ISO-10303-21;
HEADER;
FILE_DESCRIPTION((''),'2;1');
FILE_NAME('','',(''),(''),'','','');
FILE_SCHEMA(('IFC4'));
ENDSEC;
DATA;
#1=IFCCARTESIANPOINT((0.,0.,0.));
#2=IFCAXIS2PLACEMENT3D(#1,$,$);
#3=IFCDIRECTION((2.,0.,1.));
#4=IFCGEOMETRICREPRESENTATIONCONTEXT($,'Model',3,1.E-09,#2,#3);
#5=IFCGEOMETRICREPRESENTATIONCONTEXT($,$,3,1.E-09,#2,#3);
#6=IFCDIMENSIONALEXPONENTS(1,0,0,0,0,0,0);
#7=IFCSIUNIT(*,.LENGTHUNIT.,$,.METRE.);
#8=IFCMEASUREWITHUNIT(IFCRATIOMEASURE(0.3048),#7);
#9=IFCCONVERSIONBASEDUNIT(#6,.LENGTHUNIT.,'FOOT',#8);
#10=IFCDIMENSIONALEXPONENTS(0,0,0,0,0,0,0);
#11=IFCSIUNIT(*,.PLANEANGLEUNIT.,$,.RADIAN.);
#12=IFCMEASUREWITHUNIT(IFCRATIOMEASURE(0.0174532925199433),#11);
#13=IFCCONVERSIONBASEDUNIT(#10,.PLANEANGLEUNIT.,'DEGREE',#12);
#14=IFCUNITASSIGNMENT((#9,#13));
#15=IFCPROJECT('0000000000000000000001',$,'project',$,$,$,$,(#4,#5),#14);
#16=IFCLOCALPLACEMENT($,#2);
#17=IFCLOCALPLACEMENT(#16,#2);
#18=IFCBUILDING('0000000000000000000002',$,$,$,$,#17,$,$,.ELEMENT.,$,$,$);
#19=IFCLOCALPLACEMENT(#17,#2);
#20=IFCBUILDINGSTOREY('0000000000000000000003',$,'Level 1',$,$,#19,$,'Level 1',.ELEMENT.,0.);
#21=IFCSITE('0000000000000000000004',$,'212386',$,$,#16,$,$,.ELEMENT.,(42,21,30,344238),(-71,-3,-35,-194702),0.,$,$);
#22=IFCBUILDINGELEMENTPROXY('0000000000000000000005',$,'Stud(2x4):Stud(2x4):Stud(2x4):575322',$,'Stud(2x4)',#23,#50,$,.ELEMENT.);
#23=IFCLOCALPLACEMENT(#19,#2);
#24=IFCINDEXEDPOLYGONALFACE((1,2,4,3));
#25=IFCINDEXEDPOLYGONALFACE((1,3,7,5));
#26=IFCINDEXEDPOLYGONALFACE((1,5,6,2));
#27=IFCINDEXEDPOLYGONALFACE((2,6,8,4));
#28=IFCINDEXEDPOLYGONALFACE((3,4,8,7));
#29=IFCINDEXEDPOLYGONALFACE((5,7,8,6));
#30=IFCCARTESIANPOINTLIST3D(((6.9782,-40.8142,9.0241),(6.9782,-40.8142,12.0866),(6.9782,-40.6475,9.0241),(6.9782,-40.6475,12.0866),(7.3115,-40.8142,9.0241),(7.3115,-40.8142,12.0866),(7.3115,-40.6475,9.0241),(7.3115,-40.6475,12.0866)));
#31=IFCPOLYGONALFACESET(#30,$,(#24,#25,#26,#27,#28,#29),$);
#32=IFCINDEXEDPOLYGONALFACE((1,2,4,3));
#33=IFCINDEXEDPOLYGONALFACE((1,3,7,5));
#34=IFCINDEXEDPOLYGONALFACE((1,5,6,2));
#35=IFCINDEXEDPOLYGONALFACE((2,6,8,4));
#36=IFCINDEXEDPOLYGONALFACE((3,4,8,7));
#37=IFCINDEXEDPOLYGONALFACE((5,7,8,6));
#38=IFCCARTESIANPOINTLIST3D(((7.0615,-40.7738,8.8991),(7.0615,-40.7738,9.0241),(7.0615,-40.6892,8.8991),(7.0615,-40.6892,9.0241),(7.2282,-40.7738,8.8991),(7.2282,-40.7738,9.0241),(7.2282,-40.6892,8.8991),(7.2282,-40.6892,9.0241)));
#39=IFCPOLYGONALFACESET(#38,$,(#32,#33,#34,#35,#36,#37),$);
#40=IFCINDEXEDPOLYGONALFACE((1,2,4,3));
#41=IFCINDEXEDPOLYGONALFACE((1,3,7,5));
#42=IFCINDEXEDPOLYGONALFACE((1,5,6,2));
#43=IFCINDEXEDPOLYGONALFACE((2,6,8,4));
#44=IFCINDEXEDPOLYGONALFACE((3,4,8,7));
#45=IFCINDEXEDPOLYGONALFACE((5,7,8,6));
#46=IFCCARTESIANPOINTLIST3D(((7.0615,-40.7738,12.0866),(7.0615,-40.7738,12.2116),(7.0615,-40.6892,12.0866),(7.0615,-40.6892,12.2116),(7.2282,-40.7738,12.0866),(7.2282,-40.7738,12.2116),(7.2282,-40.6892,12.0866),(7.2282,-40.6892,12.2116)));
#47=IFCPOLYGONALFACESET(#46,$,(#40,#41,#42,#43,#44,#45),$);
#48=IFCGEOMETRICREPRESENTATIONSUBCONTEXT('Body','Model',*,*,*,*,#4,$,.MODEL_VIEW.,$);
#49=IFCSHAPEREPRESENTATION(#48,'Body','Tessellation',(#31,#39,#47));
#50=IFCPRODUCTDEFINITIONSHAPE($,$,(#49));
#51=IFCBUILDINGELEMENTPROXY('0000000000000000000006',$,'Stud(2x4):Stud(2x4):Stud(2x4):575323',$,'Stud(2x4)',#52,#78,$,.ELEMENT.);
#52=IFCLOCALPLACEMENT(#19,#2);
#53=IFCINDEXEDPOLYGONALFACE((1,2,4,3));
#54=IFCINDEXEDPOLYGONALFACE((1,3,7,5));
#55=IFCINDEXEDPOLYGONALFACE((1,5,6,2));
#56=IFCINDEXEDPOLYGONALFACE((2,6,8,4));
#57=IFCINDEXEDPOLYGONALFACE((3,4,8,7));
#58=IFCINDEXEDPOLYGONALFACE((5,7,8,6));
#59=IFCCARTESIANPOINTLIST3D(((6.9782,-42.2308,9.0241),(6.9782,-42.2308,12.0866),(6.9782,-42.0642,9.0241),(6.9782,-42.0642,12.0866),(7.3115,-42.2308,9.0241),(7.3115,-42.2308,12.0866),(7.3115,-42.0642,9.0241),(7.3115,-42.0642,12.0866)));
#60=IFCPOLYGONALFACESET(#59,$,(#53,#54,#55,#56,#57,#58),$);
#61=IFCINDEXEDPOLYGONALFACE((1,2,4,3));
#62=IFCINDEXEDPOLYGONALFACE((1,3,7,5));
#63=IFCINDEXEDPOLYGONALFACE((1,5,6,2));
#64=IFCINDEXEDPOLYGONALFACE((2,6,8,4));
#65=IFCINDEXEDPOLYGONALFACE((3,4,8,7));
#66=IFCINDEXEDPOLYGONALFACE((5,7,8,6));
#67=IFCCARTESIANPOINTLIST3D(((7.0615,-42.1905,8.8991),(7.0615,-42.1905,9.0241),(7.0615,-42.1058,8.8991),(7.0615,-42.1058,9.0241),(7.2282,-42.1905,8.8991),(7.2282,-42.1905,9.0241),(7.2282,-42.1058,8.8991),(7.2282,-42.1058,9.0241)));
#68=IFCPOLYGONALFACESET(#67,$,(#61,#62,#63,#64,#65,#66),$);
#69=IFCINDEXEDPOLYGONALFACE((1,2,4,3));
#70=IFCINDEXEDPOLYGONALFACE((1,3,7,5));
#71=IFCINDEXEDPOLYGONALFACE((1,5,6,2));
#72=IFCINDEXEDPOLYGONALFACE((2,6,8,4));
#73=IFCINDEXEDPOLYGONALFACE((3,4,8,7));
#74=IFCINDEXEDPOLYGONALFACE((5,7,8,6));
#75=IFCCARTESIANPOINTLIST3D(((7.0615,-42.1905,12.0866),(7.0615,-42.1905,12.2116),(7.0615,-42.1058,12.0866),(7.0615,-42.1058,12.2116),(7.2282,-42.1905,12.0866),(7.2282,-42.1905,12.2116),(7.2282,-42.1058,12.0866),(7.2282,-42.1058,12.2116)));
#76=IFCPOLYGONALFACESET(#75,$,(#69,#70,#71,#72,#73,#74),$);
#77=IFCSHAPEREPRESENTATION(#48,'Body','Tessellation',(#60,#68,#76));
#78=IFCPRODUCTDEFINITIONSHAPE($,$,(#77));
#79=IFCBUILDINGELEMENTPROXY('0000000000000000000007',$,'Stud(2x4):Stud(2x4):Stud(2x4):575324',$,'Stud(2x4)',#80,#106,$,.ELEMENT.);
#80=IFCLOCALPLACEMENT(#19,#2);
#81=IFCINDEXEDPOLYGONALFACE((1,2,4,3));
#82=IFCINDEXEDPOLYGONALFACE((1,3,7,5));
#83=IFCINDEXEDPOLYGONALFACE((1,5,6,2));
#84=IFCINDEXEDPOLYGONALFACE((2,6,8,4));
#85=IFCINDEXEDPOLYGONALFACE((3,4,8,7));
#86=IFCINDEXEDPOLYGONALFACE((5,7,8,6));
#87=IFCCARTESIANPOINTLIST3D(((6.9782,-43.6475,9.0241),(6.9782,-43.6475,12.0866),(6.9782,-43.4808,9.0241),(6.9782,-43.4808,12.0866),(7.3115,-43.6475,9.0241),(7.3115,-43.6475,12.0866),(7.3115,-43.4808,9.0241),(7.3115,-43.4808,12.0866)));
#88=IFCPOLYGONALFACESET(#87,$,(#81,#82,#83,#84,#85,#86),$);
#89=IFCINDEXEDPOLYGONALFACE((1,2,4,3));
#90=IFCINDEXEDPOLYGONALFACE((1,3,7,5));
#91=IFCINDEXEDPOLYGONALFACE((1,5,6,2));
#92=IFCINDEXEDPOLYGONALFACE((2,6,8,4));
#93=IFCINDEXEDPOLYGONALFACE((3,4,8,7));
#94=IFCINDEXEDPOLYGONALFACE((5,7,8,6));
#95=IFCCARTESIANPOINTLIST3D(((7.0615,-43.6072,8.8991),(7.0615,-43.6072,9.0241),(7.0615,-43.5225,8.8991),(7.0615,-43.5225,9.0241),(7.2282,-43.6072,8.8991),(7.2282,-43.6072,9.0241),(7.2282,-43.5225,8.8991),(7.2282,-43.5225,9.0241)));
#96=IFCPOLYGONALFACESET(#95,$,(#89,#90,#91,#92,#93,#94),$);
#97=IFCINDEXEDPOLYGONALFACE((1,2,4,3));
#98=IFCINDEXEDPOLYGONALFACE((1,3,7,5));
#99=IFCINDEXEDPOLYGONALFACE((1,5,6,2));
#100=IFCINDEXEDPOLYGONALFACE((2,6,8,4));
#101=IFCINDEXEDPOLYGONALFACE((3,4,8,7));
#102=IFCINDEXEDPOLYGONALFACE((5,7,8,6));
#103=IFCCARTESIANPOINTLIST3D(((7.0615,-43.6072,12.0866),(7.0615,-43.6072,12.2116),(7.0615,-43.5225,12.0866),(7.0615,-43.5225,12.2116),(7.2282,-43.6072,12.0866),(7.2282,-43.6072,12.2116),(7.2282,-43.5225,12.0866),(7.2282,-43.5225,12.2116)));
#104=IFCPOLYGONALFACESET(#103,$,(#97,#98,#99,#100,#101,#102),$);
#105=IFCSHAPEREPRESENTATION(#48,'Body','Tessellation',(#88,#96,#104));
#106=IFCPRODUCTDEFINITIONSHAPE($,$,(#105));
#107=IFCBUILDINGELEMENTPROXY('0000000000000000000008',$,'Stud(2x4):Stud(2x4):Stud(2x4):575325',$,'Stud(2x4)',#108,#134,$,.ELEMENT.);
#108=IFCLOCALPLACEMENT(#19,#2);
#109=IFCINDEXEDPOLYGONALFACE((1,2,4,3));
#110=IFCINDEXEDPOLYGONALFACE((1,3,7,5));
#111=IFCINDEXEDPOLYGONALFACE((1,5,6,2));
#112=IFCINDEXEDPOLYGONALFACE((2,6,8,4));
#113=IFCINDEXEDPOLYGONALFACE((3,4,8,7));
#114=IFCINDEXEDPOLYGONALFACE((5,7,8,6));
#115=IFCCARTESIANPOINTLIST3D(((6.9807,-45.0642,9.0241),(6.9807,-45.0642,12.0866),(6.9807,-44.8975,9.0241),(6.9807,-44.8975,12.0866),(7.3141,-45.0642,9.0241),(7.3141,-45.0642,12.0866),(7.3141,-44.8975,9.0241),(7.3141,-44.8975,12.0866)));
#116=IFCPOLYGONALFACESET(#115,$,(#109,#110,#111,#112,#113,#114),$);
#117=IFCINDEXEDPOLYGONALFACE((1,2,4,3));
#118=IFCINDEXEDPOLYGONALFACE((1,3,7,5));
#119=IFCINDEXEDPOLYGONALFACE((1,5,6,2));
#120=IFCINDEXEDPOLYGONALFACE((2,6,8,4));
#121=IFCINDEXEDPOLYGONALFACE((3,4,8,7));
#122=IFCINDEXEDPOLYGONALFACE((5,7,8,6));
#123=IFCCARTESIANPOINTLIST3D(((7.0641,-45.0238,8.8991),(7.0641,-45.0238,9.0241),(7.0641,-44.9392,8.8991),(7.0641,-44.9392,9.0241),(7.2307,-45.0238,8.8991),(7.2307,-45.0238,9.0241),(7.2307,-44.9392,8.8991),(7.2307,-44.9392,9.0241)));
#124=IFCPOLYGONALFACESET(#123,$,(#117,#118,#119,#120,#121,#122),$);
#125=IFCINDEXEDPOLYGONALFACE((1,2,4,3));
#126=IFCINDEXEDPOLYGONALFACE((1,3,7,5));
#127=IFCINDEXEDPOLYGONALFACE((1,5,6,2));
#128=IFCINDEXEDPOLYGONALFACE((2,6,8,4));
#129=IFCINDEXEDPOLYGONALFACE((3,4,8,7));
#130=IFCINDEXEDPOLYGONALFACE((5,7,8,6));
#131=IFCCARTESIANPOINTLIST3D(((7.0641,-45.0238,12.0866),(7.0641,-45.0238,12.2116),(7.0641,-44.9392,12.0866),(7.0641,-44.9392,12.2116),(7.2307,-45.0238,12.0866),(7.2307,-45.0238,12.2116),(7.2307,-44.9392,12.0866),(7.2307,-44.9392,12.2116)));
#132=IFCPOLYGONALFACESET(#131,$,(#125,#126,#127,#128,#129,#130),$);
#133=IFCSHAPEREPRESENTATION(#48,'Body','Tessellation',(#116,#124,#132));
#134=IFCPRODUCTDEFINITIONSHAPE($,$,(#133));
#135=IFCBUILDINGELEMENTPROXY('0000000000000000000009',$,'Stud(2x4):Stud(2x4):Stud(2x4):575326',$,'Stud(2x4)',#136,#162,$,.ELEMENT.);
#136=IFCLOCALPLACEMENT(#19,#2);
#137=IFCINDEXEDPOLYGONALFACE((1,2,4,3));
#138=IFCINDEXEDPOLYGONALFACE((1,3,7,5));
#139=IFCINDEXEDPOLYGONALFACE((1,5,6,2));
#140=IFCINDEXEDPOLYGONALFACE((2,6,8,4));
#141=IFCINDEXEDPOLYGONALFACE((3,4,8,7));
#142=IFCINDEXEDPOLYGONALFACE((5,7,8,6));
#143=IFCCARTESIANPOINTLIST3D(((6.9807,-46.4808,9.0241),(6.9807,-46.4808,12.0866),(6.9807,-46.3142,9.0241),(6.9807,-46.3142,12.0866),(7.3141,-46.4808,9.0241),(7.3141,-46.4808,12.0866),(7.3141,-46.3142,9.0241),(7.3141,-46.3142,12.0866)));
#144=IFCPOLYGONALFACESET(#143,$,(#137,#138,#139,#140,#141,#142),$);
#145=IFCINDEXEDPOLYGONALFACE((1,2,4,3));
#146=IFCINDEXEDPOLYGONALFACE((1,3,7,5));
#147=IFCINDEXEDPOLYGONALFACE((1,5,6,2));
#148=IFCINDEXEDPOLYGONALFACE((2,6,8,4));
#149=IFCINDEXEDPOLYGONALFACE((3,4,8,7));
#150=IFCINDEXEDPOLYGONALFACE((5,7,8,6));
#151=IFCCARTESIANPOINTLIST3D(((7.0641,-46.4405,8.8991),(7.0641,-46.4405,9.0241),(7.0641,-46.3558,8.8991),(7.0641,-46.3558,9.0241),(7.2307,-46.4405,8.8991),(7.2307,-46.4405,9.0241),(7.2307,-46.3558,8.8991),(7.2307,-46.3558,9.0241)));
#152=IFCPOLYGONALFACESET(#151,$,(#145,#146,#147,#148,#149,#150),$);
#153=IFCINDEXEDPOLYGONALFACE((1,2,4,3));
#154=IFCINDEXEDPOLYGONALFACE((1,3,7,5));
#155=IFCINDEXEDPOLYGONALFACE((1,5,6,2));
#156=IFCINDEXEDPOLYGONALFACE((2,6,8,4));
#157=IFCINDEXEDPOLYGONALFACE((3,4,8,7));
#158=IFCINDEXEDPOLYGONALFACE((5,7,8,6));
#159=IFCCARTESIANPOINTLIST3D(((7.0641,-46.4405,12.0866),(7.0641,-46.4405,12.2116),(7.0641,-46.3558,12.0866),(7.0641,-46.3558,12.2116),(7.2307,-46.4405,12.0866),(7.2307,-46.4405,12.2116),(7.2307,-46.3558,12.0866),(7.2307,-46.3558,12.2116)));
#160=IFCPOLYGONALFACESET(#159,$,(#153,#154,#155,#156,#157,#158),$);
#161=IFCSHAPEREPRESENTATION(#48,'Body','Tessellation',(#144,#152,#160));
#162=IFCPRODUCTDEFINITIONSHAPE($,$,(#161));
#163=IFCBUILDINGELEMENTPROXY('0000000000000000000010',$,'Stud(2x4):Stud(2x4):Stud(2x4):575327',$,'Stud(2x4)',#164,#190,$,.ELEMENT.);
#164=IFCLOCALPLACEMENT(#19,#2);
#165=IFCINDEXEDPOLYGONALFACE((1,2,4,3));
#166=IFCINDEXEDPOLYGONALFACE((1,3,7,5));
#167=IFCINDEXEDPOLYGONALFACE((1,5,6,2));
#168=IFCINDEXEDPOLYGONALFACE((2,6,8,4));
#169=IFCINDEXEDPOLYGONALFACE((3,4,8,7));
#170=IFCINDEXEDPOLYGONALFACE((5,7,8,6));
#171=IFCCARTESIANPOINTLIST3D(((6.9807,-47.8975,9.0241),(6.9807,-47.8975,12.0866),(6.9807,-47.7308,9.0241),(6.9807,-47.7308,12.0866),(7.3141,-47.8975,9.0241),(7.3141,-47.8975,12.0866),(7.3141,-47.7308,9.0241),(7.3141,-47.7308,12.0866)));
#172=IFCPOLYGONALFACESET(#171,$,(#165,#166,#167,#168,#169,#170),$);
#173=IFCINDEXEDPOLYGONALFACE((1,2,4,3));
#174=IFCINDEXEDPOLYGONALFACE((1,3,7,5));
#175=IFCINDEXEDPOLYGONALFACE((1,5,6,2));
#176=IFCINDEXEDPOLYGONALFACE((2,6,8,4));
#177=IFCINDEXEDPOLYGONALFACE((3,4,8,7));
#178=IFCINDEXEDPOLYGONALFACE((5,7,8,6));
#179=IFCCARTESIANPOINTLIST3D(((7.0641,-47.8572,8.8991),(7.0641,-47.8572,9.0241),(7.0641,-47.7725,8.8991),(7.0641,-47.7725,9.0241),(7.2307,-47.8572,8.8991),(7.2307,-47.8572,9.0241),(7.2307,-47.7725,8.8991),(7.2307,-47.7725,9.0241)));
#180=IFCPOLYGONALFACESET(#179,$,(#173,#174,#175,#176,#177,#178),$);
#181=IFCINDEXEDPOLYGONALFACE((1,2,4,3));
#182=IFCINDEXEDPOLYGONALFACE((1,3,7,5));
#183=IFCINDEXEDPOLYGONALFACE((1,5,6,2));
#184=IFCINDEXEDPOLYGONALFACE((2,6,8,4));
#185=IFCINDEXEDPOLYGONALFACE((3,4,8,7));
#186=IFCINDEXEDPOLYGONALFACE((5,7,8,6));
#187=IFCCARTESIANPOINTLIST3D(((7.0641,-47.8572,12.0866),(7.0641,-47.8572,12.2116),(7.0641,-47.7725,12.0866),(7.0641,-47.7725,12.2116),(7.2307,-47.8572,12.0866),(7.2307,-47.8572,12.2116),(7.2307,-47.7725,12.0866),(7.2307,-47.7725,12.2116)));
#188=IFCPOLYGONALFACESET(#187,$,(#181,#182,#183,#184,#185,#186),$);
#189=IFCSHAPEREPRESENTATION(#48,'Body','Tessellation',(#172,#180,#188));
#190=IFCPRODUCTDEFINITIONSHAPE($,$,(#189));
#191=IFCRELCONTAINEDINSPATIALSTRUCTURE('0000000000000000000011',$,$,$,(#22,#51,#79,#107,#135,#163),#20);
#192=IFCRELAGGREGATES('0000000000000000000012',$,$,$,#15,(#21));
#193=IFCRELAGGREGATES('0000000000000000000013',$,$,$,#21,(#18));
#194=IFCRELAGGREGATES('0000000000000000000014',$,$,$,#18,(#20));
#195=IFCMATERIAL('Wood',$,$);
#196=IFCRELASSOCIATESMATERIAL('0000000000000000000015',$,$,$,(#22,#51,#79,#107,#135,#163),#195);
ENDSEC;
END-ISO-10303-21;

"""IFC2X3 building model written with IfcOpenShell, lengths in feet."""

from ifc_helpers import new_model, entity, si_unit, converted_unit, direction, frame, frame_2d, origin, place, context, subcontext, project, spatial, rectangle, extrude, source, transform, mapped, material, element, save


model = new_model("IFC2X3")

# Units and contexts
model_context = context("Model", 3, precision=1e-09, world=origin(), true_north=direction((2.0, 0.0, 1.0)))
context_of_model = context(None, 3, precision=1e-09, world=origin(), true_north=direction((2.0, 0.0, 1.0)))
body_context = subcontext(model_context, "Body", "Model", "MODEL_VIEW")
ifc_project = project(units=[converted_unit("LENGTHUNIT", "FOOT", entity("IfcRatioMeasure", 0.3048), si_unit("LENGTHUNIT", "METRE"), dimensions=[1, 0, 0, 0, 0, 0, 0]), converted_unit("PLANEANGLEUNIT", "DEGREE", entity("IfcRatioMeasure", 0.0174532925199433), si_unit("PLANEANGLEUNIT", "RADIAN"), dimensions=[0, 0, 0, 0, 0, 0, 0])], contexts=[model_context, context_of_model])

# Site, building, storey
site_placement = place(None, origin())
site = spatial("IfcSite", under=ifc_project, at=site_placement, Name="212386", CompositionType="ELEMENT", RefLatitude=(42, 21, 30, 344238), RefLongitude=(-71, -3, -35, -194702), RefElevation=0.0)
building_placement = place(site_placement, origin())
building = spatial("IfcBuilding", under=site, at=building_placement, CompositionType="ELEMENT")
storey_placement = place(building_placement, origin())
storey = spatial("IfcBuildingStorey", under=building, at=storey_placement, Name="Level 1", LongName="Level 1", CompositionType="ELEMENT", Elevation=0.0)

# Building element proxies
ifc_material = material(Name="Wood")
shared_shape_1 = source(origin(), body_context, "Body", "SweptSolid", [
    extrude(rectangle(XDim=0.3333, YDim=0.1667, at=frame_2d((0.0, 0.0), x_axis=(1.0, 0.0))), frame((7.1448, -40.7308, 9.0241), z_axis=(0.0, 0.0, 1.0), x_axis=(-1.0, 0.0, 0.0)), (0.0, 0.0, 1.0), 3.0625),
    extrude(rectangle(XDim=0.1667, YDim=0.0847, at=frame_2d((0.0, 0.0), x_axis=(1.0, 0.0))), frame((7.1448, -40.7315, 8.8991), z_axis=(0.0, 0.0, 1.0), x_axis=(-1.0, 0.0, 0.0)), (0.0, 0.0, 1.0), 0.125),
    extrude(rectangle(XDim=0.0847, YDim=0.1667, at=frame_2d((0.0, 0.0), x_axis=(1.0, 0.0))), frame((7.1448, -40.7315, 12.0866), z_axis=(0.0, 0.0, 1.0), x_axis=(0.0, -1.0, 0.0)), (0.0, 0.0, 1.0), 0.125),
])
proxy_1_placement = place(storey_placement, origin())
element("IfcBuildingElementProxy", 1, at=proxy_1_placement, inside=storey, material=ifc_material, Name="Stud(2x4):Stud(2x4):Stud(2x4):575322", ObjectType="Stud(2x4)", CompositionType="ELEMENT", context=body_context, shape_type="MappedRepresentation", body=[
    mapped(shared_shape_1, transform((0.0, 0.0, 0.0), scale=1.0)),
])
shared_shape_2 = source(origin(), body_context, "Body", "SweptSolid", [
    extrude(rectangle(XDim=0.3333, YDim=0.1667, at=frame_2d((0.0, 0.0), x_axis=(1.0, 0.0))), frame((7.1448, -42.1475, 9.0241), z_axis=(0.0, 0.0, 1.0), x_axis=(-1.0, 0.0, 0.0)), (0.0, 0.0, 1.0), 3.0625),
    extrude(rectangle(XDim=0.1667, YDim=0.0847, at=frame_2d((0.0, 0.0), x_axis=(1.0, 0.0))), frame((7.1448, -42.1482, 8.8991), z_axis=(0.0, 0.0, 1.0), x_axis=(-1.0, 0.0, 0.0)), (0.0, 0.0, 1.0), 0.125),
    extrude(rectangle(XDim=0.0847, YDim=0.1667, at=frame_2d((0.0, 0.0), x_axis=(1.0, 0.0))), frame((7.1448, -42.1482, 12.0866), z_axis=(0.0, 0.0, 1.0), x_axis=(0.0, -1.0, 0.0)), (0.0, 0.0, 1.0), 0.125),
])
proxy_2_placement = place(storey_placement, origin())
element("IfcBuildingElementProxy", 2, at=proxy_2_placement, inside=storey, material=ifc_material, Name="Stud(2x4):Stud(2x4):Stud(2x4):575323", ObjectType="Stud(2x4)", CompositionType="ELEMENT", context=body_context, shape_type="MappedRepresentation", body=[
    mapped(shared_shape_2, transform((0.0, 0.0, 0.0), scale=1.0)),
])
shared_shape_3 = source(origin(), body_context, "Body", "SweptSolid", [
    extrude(rectangle(XDim=0.3333, YDim=0.1667, at=frame_2d((0.0, 0.0), x_axis=(1.0, 0.0))), frame((7.1448, -43.5642, 9.0241), z_axis=(0.0, 0.0, 1.0), x_axis=(-1.0, 0.0, 0.0)), (0.0, 0.0, 1.0), 3.0625),
    extrude(rectangle(XDim=0.1667, YDim=0.0847, at=frame_2d((0.0, 0.0), x_axis=(1.0, 0.0))), frame((7.1448, -43.5648, 8.8991), z_axis=(0.0, 0.0, 1.0), x_axis=(-1.0, 0.0, 0.0)), (0.0, 0.0, 1.0), 0.125),
    extrude(rectangle(XDim=0.0847, YDim=0.1667, at=frame_2d((0.0, 0.0), x_axis=(1.0, 0.0))), frame((7.1448, -43.5648, 12.0866), z_axis=(0.0, 0.0, 1.0), x_axis=(0.0, -1.0, 0.0)), (0.0, 0.0, 1.0), 0.125),
])
proxy_3_placement = place(storey_placement, origin())
element("IfcBuildingElementProxy", 3, at=proxy_3_placement, inside=storey, material=ifc_material, Name="Stud(2x4):Stud(2x4):Stud(2x4):575324", ObjectType="Stud(2x4)", CompositionType="ELEMENT", context=body_context, shape_type="MappedRepresentation", body=[
    mapped(shared_shape_3, transform((0.0, 0.0, 0.0), scale=1.0)),
])
shared_shape_4 = source(origin(), body_context, "Body", "SweptSolid", [
    extrude(rectangle(XDim=0.3333, YDim=0.1667, at=frame_2d((0.0, 0.0), x_axis=(1.0, 0.0))), frame((7.1474, -44.9808, 9.0241), z_axis=(0.0, 0.0, 1.0), x_axis=(-1.0, 0.0, 0.0)), (0.0, 0.0, 1.0), 3.0625),
    extrude(rectangle(XDim=0.1667, YDim=0.0847, at=frame_2d((0.0, 0.0), x_axis=(1.0, 0.0))), frame((7.1474, -44.9815, 8.8991), z_axis=(0.0, 0.0, 1.0), x_axis=(-1.0, 0.0, 0.0)), (0.0, 0.0, 1.0), 0.125),
    extrude(rectangle(XDim=0.0847, YDim=0.1667, at=frame_2d((0.0, 0.0), x_axis=(1.0, 0.0))), frame((7.1474, -44.9815, 12.0866), z_axis=(0.0, 0.0, 1.0), x_axis=(0.0, -1.0, 0.0)), (0.0, 0.0, 1.0), 0.125),
])
proxy_4_placement = place(storey_placement, origin())
element("IfcBuildingElementProxy", 4, at=proxy_4_placement, inside=storey, material=ifc_material, Name="Stud(2x4):Stud(2x4):Stud(2x4):575325", ObjectType="Stud(2x4)", CompositionType="ELEMENT", context=body_context, shape_type="MappedRepresentation", body=[
    mapped(shared_shape_4, transform((0.0, 0.0, 0.0), scale=1.0)),
])
shared_shape_5 = source(origin(), body_context, "Body", "SweptSolid", [
    extrude(rectangle(XDim=0.3333, YDim=0.1667, at=frame_2d((0.0, 0.0), x_axis=(1.0, 0.0))), frame((7.1474, -46.3975, 9.0241), z_axis=(0.0, 0.0, 1.0), x_axis=(-1.0, 0.0, 0.0)), (0.0, 0.0, 1.0), 3.0625),
    extrude(rectangle(XDim=0.1667, YDim=0.0847, at=frame_2d((0.0, 0.0), x_axis=(1.0, 0.0))), frame((7.1474, -46.3982, 8.8991), z_axis=(0.0, 0.0, 1.0), x_axis=(-1.0, 0.0, 0.0)), (0.0, 0.0, 1.0), 0.125),
    extrude(rectangle(XDim=0.0847, YDim=0.1667, at=frame_2d((0.0, 0.0), x_axis=(1.0, 0.0))), frame((7.1474, -46.3982, 12.0866), z_axis=(0.0, 0.0, 1.0), x_axis=(0.0, -1.0, 0.0)), (0.0, 0.0, 1.0), 0.125),
])
proxy_5_placement = place(storey_placement, origin())
element("IfcBuildingElementProxy", 5, at=proxy_5_placement, inside=storey, material=ifc_material, Name="Stud(2x4):Stud(2x4):Stud(2x4):575326", ObjectType="Stud(2x4)", CompositionType="ELEMENT", context=body_context, shape_type="MappedRepresentation", body=[
    mapped(shared_shape_5, transform((0.0, 0.0, 0.0), scale=1.0)),
])
shared_shape_6 = source(origin(), body_context, "Body", "SweptSolid", [
    extrude(rectangle(XDim=0.3333, YDim=0.1667, at=frame_2d((0.0, 0.0), x_axis=(1.0, 0.0))), frame((7.1474, -47.8142, 9.0241), z_axis=(0.0, 0.0, 1.0), x_axis=(-1.0, 0.0, 0.0)), (0.0, 0.0, 1.0), 3.0625),
    extrude(rectangle(XDim=0.1667, YDim=0.0847, at=frame_2d((0.0, 0.0), x_axis=(1.0, 0.0))), frame((7.1474, -47.8148, 8.8991), z_axis=(0.0, 0.0, 1.0), x_axis=(-1.0, 0.0, 0.0)), (0.0, 0.0, 1.0), 0.125),
    extrude(rectangle(XDim=0.0847, YDim=0.1667, at=frame_2d((0.0, 0.0), x_axis=(1.0, 0.0))), frame((7.1474, -47.8148, 12.0866), z_axis=(0.0, 0.0, 1.0), x_axis=(0.0, -1.0, 0.0)), (0.0, 0.0, 1.0), 0.125),
])
proxy_6_placement = place(storey_placement, origin())
element("IfcBuildingElementProxy", 6, at=proxy_6_placement, inside=storey, material=ifc_material, Name="Stud(2x4):Stud(2x4):Stud(2x4):575327", ObjectType="Stud(2x4)", CompositionType="ELEMENT", context=body_context, shape_type="MappedRepresentation", body=[
    mapped(shared_shape_6, transform((0.0, 0.0, 0.0), scale=1.0)),
])

save(model, "model.ifc")
